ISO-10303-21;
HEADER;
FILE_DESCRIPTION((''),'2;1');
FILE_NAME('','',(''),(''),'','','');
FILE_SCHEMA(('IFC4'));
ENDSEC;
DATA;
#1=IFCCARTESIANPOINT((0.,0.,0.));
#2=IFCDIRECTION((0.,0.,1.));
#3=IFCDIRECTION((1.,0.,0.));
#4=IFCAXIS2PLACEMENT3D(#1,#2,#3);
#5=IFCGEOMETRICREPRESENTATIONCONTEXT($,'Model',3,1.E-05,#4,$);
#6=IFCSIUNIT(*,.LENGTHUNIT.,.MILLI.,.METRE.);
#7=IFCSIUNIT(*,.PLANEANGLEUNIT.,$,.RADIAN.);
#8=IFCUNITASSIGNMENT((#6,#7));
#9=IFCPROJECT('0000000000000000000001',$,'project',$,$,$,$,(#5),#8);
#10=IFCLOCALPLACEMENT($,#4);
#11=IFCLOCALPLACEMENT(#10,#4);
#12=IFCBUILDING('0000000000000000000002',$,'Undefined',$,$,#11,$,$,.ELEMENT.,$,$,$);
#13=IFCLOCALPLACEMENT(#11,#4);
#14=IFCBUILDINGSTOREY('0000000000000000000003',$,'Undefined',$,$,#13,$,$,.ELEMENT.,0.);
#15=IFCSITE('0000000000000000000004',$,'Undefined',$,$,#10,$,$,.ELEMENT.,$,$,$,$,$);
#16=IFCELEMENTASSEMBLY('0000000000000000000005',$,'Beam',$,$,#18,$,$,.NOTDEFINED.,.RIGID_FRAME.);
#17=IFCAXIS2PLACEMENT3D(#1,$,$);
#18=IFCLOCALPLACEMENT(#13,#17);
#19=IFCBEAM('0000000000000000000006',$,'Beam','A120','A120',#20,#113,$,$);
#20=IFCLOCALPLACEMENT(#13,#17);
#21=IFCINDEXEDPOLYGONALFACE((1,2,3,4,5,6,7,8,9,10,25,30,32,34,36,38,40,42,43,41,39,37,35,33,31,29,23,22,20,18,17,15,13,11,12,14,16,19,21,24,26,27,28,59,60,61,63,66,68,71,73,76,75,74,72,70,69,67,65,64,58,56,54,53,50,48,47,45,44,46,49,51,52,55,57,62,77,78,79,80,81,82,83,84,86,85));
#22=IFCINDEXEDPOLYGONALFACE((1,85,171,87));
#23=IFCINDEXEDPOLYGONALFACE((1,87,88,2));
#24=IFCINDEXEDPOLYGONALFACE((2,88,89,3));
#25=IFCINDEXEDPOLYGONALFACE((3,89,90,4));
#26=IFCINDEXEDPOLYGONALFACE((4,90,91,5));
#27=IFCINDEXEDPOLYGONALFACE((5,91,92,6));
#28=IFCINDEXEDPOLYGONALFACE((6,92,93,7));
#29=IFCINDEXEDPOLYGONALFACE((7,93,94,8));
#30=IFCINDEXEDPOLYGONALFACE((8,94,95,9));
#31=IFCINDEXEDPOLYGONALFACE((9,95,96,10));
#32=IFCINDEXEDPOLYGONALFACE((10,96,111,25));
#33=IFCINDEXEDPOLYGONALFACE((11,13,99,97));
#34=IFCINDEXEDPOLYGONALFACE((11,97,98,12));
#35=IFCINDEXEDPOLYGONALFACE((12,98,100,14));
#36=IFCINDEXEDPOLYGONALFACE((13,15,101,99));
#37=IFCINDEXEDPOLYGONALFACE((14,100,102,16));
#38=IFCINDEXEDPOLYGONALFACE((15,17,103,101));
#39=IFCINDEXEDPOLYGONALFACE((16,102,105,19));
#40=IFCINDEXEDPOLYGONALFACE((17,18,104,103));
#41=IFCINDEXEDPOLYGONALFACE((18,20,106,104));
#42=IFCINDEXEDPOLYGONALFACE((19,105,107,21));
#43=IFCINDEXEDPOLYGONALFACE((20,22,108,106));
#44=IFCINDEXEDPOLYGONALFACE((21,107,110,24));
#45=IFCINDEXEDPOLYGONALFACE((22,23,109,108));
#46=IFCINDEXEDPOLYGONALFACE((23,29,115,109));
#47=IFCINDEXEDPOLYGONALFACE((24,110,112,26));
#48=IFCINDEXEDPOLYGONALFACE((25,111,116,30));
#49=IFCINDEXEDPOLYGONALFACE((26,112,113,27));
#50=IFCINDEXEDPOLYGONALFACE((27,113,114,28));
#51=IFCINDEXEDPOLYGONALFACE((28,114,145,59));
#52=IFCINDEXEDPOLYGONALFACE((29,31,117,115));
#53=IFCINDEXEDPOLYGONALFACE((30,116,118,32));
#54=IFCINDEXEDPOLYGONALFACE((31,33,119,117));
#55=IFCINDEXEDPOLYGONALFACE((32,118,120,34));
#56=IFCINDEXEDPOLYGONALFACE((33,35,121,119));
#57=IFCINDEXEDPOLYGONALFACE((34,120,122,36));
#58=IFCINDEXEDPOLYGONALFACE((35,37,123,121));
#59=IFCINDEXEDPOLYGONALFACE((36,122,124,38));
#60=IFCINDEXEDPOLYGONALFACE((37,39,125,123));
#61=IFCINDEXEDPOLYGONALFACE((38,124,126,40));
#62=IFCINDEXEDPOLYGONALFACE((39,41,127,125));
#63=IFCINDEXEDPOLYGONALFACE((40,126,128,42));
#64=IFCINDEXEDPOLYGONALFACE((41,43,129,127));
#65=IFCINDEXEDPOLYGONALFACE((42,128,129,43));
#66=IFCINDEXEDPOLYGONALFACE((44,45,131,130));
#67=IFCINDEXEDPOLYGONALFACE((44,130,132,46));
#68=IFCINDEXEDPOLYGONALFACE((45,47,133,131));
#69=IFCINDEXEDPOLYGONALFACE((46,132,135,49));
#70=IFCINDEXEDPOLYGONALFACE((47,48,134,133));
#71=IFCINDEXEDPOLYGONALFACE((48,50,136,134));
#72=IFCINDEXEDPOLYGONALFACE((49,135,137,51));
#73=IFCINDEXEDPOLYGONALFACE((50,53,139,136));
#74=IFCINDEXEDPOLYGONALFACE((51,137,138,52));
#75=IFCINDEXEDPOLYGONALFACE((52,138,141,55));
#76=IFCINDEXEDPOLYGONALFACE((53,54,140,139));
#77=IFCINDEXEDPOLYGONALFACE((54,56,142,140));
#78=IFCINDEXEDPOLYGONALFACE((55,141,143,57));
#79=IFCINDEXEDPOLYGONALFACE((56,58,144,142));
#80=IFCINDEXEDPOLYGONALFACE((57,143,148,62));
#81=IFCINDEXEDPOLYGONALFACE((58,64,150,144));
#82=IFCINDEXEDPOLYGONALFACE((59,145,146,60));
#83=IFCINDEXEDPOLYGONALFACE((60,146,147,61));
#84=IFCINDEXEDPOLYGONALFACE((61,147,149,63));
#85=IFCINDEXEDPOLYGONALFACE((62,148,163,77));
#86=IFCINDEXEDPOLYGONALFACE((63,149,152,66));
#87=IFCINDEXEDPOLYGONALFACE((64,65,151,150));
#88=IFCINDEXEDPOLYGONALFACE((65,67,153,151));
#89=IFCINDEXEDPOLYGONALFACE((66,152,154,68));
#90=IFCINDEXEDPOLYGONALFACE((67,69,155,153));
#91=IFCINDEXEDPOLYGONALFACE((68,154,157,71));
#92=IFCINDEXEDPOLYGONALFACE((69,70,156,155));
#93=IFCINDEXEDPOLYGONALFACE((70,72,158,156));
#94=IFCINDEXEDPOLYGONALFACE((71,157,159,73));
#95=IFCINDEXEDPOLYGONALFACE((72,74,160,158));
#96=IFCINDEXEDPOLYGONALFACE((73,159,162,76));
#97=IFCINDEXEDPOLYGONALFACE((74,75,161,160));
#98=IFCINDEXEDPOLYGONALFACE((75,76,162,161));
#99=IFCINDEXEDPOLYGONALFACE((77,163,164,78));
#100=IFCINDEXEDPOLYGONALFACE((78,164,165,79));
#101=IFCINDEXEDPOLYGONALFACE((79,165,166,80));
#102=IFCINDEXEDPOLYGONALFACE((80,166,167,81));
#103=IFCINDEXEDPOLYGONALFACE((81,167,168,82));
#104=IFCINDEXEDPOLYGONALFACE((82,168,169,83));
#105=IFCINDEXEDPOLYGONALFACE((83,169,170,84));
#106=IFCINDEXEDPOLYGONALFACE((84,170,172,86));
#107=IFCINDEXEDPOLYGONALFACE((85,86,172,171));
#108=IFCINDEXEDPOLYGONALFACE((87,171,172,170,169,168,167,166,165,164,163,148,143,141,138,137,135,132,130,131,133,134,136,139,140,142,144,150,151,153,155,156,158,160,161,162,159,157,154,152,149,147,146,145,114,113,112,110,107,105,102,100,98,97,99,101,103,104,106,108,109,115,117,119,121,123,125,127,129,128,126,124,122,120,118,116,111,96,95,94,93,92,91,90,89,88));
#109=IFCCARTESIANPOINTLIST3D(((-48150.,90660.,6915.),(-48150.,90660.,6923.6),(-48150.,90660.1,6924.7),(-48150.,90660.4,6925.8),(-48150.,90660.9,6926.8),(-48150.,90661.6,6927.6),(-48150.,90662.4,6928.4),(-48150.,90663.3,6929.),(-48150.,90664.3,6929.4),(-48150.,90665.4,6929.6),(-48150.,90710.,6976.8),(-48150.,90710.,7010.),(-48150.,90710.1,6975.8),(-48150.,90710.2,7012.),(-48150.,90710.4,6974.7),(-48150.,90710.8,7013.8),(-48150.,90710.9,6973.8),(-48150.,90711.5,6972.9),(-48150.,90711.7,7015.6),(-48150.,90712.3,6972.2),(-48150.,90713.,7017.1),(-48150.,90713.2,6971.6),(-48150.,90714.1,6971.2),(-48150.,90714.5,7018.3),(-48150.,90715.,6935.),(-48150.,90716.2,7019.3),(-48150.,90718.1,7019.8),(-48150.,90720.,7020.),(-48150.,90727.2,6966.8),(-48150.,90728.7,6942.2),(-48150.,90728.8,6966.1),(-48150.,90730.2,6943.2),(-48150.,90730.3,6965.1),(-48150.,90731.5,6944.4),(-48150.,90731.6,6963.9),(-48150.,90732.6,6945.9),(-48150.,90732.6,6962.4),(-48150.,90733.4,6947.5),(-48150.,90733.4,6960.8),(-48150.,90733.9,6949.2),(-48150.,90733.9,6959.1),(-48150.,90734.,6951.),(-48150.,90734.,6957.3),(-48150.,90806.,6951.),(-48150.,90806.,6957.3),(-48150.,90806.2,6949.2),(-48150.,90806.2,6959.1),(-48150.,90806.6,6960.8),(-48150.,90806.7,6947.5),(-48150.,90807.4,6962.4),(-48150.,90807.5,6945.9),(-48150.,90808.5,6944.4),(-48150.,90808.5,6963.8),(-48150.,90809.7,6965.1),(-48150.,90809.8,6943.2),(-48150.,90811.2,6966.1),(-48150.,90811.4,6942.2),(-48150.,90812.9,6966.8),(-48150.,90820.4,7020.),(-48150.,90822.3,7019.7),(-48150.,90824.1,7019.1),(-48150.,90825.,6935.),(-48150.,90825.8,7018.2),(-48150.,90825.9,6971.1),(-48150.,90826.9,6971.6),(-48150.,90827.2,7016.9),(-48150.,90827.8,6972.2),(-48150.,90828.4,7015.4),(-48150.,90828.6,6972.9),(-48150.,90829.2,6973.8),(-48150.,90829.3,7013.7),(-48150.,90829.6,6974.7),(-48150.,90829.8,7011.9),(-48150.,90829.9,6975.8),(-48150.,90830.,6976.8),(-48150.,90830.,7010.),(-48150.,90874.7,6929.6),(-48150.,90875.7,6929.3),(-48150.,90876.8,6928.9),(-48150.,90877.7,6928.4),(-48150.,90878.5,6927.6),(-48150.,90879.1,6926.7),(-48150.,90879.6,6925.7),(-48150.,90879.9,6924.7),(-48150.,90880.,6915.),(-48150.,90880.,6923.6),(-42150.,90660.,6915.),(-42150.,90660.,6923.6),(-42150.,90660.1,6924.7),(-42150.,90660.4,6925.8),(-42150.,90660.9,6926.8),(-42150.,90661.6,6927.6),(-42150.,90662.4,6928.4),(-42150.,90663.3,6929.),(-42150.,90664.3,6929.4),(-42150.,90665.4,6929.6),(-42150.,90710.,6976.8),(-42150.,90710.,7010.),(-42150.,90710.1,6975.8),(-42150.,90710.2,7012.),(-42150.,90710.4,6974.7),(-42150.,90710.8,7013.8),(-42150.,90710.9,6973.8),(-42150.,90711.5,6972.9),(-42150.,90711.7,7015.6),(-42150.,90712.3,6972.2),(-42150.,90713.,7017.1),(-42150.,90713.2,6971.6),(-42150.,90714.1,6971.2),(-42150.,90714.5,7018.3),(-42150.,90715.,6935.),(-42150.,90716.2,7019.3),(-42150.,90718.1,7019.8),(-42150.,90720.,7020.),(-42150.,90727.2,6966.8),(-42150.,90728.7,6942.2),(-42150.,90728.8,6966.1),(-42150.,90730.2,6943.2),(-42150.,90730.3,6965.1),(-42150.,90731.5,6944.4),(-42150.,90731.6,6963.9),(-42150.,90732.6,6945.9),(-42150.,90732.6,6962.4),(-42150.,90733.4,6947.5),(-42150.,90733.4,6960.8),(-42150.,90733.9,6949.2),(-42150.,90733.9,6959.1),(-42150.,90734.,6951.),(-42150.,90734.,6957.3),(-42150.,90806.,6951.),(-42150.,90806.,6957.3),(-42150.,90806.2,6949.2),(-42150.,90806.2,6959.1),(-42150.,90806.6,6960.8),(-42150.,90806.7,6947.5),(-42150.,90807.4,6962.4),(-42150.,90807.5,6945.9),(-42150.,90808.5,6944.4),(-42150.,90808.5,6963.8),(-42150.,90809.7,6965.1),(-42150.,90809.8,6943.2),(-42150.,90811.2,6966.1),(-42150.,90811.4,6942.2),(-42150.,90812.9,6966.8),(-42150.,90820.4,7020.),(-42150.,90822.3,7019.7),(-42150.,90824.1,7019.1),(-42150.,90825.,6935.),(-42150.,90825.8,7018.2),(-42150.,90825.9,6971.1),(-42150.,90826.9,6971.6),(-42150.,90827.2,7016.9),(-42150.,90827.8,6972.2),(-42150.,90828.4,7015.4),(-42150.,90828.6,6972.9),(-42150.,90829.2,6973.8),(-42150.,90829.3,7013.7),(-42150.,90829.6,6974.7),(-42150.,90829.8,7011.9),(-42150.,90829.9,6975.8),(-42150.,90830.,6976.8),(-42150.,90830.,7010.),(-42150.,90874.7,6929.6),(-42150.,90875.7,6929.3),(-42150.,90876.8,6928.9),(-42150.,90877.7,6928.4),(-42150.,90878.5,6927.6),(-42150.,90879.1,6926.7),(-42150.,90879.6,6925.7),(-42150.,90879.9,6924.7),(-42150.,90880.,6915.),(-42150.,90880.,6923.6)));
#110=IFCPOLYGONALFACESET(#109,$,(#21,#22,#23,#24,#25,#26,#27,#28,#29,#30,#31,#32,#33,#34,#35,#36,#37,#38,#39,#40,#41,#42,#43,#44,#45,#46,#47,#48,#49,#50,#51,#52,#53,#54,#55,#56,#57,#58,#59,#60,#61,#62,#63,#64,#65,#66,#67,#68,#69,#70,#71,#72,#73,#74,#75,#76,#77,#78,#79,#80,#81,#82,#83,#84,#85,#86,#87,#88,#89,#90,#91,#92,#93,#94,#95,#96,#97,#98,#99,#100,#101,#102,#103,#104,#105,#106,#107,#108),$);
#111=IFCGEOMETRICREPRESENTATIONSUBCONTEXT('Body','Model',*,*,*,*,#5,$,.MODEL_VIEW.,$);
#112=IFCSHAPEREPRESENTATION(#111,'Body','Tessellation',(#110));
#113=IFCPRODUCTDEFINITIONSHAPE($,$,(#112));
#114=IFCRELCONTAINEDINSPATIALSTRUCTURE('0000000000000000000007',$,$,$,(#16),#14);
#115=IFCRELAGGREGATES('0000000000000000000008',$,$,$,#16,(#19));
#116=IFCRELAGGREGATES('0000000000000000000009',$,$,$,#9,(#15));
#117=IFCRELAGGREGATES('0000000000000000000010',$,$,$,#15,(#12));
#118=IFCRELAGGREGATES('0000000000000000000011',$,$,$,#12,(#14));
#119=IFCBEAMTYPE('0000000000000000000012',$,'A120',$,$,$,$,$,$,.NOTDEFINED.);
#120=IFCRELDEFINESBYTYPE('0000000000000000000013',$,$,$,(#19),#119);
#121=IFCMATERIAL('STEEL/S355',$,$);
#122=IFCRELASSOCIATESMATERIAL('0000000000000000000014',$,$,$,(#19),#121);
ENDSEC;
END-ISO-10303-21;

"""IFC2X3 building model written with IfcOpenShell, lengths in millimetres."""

from ifc_helpers import new_model, si_unit, frame, origin_with_axes, place, context, subcontext, project, spatial, polyline, outline, extrude, material, type_object, element, aggregate, save


model = new_model("IFC2X3")

# Units and contexts
model_context = context("Model", 3, precision=1e-05, world=origin_with_axes())
body_context = subcontext(model_context, "Body", "Model", "MODEL_VIEW")
ifc_project = project(units=[si_unit("LENGTHUNIT", "METRE", prefix="MILLI"), si_unit("PLANEANGLEUNIT", "RADIAN")], contexts=[model_context])

# Site, building, storey
site_placement = place(None, origin_with_axes())
site = spatial("IfcSite", under=ifc_project, at=site_placement, Name="Undefined", CompositionType="ELEMENT")
building_placement = place(site_placement, origin_with_axes())
building = spatial("IfcBuilding", under=site, at=building_placement, Name="Undefined", CompositionType="ELEMENT")
storey_placement = place(building_placement, origin_with_axes())
storey = spatial("IfcBuildingStorey", under=building, at=storey_placement, Name="Undefined", CompositionType="ELEMENT", Elevation=0.0)

# Element assembly, beam
ifc_material_1 = material(Name="STEEL/S355")
beam_type_1 = type_object("IfcBeamType", Name="A120", PredefinedType="NOTDEFINED")
assembly_1_placement = place(storey_placement, origin_with_axes())
assembly_1 = element("IfcElementAssembly", 1, at=assembly_1_placement, inside=storey, Name="Beam", AssemblyPlace="NOTDEFINED", PredefinedType="RIGID_FRAME")
beam_1_placement = place(assembly_1_placement, frame((-48150.0, 90770.0, 6967.5), z_axis=(0.0, 0.000118, 1.0), x_axis=(1.0, 0.0, 0.0)))
beam_1 = element("IfcBeam", 2, at=beam_1_placement, type_object=beam_type_1, material=ifc_material_1, Name="Beam", Description="A120", ObjectType="A120", context=body_context, shape_type="SweptSolid", body=[
    extrude(outline(polyline([(-110.0, -52.5), (-110.0, -43.9), (-109.9, -42.8), (-109.6, -41.8), (-109.1, -40.8), (-108.5, -39.9), (-107.7, -39.1), (-106.7, -38.6), (-105.7, -38.2), (-104.7, -37.9), (-55.0, -32.5), (-41.3, -25.3), (-39.8, -24.3), (-38.5, -23.1), (-37.4, -21.6), (-36.6, -20.0), (-36.2, -18.3), (-36.0, -16.5), (-36.0, -10.2), (-36.1, -8.4), (-36.6, -6.7), (-37.4, -5.1), (-38.4, -3.7), (-39.7, -2.4), (-41.2, -1.4), (-42.8, -0.7), (-55.9, 3.6), (-56.9, 4.1), (-57.8, 4.7), (-58.5, 5.4), (-59.2, 6.3), (-59.6, 7.2), (-59.9, 8.3), (-60.0, 9.3), (-60.0, 42.5), (-59.8, 44.4), (-59.3, 46.2), (-58.4, 47.9), (-57.2, 49.4), (-55.7, 50.7), (-54.1, 51.6), (-52.3, 52.2), (-50.4, 52.5), (50.0, 52.5), (51.9, 52.3), (53.8, 51.7), (55.5, 50.8), (57.1, 49.6), (58.3, 48.1), (59.2, 46.3), (59.8, 44.4), (60.0, 42.5), (60.0, 9.3), (59.9, 8.3), (59.6, 7.2), (59.2, 6.3), (58.5, 5.4), (57.8, 4.7), (56.9, 4.1), (55.9, 3.6), (42.8, -0.7), (41.2, -1.4), (39.7, -2.4), (38.4, -3.7), (37.4, -5.1), (36.6, -6.7), (36.1, -8.4), (36.0, -10.2), (36.0, -16.5), (36.2, -18.3), (36.6, -20.0), (37.4, -21.6), (38.5, -23.1), (39.8, -24.3), (41.3, -25.3), (55.0, -32.5), (104.7, -37.9), (105.7, -38.2), (106.7, -38.6), (107.7, -39.1), (108.5, -39.9), (109.1, -40.8), (109.6, -41.8), (109.9, -42.8), (110.0, -43.9), (110.0, -52.5), (-110.0, -52.5)])), frame((6000.0, 0.0, 0.0), z_axis=(-1.0, 0.0, 0.0), x_axis=(0.0, -1.0, 0.0)), (0.0, 0.0, 1.0), 6000.0),
])
aggregate(assembly_1, [beam_1])

save(model, "model.ifc")
